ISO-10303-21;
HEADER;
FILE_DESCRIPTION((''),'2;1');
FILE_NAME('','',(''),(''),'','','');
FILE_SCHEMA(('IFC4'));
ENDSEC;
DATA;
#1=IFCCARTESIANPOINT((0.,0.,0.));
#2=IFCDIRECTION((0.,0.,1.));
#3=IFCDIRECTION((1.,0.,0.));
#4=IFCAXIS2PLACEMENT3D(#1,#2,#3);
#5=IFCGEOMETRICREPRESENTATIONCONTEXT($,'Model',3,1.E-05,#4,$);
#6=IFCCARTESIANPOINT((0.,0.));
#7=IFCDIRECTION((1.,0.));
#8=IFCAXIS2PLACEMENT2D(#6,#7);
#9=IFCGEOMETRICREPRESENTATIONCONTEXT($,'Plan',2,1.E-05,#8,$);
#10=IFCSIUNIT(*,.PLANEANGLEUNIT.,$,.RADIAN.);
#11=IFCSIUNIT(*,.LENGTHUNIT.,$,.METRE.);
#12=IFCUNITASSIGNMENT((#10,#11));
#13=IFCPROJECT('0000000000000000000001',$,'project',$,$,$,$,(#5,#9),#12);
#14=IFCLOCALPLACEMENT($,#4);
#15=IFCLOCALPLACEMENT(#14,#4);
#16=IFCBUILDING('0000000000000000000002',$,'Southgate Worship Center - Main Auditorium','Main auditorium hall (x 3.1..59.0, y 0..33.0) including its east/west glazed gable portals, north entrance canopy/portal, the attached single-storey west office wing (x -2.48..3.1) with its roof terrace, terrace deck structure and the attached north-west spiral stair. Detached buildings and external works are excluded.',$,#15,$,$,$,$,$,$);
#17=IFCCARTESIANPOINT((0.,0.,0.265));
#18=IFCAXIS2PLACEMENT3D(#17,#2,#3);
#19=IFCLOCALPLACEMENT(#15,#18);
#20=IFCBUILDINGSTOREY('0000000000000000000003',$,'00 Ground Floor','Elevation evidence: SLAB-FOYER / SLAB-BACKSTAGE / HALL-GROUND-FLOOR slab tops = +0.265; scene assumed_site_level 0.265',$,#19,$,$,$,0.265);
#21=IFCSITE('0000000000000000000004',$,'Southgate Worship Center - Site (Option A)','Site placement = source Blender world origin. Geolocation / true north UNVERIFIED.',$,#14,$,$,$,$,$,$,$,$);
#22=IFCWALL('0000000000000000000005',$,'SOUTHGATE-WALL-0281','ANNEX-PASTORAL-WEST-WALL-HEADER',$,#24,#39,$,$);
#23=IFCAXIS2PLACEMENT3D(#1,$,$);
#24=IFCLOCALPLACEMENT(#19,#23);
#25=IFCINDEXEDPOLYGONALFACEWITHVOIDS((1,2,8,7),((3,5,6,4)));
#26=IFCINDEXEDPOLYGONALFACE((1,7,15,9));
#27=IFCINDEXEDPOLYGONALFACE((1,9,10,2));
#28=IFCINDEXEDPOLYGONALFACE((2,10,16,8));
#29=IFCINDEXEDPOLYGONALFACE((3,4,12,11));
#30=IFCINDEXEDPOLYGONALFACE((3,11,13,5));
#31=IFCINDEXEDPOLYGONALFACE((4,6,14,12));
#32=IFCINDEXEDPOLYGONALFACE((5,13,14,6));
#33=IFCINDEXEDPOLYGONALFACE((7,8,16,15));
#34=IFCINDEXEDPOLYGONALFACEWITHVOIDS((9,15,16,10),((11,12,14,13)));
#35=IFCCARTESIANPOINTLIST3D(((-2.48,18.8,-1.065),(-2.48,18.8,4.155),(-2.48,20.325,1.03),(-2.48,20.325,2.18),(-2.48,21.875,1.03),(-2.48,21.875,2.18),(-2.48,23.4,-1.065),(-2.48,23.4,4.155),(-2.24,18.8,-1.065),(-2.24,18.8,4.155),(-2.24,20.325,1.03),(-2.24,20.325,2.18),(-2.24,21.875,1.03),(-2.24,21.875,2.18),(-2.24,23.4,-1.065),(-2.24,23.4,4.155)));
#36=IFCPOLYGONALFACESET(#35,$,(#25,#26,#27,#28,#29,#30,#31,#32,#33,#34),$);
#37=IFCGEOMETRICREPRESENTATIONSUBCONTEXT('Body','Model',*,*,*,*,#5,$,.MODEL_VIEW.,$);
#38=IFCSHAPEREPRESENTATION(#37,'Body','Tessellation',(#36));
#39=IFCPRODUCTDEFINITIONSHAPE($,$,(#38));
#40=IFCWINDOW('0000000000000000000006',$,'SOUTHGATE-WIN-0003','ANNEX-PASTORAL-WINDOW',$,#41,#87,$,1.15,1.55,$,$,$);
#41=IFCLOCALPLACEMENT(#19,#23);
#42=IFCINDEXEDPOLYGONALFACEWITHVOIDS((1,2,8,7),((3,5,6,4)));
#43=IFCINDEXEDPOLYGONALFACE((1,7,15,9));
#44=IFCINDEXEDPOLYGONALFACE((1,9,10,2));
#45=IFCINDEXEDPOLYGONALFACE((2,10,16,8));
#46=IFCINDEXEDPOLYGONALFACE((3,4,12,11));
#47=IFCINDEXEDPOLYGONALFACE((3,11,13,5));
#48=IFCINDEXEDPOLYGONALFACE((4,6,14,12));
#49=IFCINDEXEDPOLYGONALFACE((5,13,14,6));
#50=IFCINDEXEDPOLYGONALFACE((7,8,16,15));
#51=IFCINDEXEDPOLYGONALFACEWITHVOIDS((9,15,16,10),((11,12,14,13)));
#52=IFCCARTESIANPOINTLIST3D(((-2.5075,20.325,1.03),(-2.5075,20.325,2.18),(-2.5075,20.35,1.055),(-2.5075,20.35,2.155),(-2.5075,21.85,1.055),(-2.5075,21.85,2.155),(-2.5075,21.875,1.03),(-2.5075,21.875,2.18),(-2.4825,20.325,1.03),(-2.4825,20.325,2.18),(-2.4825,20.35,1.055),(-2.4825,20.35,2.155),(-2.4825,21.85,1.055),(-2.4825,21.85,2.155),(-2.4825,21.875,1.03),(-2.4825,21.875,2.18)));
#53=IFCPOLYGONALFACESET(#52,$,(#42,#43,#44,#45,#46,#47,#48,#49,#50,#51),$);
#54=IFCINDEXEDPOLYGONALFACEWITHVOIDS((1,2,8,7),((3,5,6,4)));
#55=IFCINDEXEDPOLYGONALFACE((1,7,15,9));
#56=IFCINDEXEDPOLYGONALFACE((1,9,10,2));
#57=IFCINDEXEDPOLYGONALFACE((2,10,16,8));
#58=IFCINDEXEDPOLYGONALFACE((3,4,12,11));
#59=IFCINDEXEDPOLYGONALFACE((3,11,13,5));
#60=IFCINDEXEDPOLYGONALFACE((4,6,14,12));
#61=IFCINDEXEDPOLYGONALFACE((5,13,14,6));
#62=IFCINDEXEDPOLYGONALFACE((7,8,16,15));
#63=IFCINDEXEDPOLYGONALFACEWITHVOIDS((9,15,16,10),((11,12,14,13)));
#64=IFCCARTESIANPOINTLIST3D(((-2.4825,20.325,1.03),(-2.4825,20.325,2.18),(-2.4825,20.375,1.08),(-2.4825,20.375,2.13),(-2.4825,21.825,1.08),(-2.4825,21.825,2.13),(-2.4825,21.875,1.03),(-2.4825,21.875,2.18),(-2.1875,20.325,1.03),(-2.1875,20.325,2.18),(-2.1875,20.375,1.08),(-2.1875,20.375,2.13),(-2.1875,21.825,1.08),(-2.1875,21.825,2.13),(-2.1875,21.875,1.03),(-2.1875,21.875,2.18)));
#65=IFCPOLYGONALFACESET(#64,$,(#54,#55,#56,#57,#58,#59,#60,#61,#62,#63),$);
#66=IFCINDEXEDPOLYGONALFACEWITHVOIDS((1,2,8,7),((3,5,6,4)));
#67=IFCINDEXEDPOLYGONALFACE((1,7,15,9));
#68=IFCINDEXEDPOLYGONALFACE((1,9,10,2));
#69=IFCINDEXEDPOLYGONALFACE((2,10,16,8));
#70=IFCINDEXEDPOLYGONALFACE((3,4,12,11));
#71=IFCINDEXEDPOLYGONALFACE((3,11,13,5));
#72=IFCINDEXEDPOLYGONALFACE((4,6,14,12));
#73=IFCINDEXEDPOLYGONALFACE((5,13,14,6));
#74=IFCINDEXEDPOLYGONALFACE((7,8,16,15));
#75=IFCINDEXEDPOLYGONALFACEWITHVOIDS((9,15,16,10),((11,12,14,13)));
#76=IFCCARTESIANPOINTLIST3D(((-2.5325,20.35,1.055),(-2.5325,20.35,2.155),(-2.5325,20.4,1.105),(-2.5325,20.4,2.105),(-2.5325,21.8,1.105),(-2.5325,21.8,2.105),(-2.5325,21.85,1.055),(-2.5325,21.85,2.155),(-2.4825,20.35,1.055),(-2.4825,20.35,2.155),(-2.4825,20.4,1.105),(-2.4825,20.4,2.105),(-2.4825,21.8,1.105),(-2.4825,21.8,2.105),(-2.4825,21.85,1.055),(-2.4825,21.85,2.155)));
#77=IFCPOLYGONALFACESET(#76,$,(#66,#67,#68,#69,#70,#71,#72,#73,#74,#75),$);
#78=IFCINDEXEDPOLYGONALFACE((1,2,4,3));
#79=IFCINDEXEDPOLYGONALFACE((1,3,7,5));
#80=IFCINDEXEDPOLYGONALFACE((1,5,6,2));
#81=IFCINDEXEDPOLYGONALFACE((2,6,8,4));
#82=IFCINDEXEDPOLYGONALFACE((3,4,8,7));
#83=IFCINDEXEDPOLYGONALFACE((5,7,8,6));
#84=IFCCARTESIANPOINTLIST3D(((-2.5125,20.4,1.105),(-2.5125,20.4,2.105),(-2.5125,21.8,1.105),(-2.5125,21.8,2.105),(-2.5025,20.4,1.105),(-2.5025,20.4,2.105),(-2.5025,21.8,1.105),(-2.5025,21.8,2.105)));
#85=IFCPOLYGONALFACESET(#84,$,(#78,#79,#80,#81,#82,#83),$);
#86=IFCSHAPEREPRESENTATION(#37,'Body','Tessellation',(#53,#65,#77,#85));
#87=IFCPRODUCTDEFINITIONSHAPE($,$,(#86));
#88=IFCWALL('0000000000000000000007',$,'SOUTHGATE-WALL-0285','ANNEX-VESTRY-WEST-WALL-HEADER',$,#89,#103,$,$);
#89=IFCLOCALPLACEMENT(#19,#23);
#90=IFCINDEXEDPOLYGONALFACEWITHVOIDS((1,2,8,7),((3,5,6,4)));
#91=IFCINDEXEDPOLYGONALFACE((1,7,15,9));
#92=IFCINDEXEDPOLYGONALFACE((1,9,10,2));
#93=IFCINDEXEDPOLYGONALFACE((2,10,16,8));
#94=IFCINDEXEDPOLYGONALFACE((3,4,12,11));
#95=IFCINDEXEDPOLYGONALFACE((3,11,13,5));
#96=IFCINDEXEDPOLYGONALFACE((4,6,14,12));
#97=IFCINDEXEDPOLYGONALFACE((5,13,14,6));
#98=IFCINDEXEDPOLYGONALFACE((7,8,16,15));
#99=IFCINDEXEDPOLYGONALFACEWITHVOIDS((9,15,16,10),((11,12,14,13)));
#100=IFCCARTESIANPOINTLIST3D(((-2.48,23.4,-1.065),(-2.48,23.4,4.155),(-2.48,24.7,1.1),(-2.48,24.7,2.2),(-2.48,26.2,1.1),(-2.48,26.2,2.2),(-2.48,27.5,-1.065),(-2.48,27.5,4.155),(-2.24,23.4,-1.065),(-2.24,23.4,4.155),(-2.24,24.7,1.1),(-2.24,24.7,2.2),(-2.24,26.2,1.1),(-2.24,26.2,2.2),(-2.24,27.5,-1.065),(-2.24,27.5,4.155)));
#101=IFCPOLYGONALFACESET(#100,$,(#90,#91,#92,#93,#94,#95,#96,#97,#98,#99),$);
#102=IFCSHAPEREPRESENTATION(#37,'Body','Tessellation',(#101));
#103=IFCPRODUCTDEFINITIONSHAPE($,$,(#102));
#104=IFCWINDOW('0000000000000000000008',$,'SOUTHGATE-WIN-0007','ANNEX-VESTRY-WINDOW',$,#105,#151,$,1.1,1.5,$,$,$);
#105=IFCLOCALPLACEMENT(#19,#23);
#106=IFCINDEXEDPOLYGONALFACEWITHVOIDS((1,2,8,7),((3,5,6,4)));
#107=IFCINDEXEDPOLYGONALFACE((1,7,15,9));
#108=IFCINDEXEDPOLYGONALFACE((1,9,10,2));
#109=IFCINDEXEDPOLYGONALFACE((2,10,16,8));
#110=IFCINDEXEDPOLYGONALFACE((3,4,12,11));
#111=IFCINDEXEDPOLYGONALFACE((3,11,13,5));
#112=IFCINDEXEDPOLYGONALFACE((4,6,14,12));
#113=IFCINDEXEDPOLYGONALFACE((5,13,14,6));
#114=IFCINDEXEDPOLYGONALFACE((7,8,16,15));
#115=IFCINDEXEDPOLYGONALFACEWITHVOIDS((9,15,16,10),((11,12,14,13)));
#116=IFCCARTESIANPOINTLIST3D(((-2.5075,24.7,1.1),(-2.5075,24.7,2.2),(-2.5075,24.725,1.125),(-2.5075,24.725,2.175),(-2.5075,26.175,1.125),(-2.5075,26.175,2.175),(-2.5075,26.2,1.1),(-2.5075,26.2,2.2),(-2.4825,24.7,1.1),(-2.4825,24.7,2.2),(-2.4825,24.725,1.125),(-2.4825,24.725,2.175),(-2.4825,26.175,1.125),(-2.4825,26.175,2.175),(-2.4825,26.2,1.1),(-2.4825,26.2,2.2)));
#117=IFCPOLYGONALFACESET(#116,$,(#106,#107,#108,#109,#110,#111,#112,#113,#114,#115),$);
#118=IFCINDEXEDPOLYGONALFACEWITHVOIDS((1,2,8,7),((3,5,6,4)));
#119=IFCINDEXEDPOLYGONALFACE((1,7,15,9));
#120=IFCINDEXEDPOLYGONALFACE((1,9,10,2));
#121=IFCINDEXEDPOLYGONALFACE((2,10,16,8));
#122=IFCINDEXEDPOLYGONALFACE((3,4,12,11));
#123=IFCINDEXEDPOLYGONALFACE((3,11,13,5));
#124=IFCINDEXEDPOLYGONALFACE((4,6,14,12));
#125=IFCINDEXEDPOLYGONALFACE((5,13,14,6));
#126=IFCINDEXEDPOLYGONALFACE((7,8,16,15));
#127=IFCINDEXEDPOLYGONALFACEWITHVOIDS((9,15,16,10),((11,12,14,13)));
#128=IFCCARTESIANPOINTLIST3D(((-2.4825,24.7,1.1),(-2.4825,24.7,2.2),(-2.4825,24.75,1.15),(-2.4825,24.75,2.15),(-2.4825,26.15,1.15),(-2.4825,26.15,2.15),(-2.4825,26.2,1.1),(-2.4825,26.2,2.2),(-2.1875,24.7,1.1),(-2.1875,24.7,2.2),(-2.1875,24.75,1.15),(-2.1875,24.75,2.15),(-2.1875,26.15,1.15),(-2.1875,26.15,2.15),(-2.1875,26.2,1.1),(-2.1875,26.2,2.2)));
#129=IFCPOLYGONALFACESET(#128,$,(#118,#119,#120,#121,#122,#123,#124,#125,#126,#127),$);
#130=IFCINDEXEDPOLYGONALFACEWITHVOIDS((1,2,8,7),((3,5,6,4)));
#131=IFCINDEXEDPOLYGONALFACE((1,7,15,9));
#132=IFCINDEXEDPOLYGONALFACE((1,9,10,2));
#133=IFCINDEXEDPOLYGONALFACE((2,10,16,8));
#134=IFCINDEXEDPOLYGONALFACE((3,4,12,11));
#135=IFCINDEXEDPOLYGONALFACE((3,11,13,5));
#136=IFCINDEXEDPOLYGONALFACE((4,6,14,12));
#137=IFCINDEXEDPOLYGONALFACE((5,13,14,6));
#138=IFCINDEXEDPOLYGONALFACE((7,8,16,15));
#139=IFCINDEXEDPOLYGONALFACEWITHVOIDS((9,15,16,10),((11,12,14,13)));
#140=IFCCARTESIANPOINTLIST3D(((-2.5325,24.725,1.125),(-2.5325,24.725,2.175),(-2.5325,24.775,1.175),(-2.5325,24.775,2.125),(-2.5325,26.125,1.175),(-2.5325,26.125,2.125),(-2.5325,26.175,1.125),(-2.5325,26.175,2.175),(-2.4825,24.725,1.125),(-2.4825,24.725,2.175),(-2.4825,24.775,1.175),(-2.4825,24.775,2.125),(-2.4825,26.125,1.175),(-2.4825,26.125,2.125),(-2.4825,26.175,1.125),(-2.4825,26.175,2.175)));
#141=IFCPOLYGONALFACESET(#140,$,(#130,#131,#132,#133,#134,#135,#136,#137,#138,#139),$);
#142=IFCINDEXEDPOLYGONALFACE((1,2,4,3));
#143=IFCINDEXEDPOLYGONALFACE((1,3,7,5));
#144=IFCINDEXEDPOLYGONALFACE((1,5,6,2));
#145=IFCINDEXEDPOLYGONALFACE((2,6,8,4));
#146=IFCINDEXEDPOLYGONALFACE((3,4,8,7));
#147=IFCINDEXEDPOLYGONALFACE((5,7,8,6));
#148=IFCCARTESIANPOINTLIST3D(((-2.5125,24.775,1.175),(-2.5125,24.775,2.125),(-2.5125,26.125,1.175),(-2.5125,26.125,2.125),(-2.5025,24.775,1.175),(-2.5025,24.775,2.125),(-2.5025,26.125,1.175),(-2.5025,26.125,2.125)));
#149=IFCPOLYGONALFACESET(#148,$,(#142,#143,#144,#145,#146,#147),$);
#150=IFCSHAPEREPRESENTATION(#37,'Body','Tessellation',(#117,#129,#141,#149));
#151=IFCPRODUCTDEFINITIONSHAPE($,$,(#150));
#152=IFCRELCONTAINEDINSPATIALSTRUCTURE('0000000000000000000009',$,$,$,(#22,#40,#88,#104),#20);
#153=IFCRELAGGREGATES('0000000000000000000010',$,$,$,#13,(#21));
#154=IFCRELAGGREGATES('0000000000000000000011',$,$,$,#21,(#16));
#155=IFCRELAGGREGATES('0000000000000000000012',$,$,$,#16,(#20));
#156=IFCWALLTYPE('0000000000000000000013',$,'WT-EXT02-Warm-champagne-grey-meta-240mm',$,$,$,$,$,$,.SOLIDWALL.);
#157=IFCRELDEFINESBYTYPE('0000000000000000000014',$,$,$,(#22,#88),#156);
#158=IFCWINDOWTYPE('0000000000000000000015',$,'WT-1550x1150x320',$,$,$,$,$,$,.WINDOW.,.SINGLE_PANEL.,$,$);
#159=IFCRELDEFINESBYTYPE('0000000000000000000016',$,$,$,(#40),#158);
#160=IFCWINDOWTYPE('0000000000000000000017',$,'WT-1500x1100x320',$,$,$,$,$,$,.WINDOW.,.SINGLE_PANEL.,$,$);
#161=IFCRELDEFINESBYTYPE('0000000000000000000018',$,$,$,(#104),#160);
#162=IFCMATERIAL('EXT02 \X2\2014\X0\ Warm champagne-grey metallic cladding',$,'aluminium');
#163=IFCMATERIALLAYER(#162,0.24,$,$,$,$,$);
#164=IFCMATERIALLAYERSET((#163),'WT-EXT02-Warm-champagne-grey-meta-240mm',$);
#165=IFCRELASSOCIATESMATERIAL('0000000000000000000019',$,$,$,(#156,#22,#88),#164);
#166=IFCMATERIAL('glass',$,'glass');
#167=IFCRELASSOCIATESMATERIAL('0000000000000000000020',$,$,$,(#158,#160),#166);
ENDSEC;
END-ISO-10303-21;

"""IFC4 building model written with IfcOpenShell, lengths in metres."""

from ifc_helpers import new_model, si_unit, frame, frame_2d, origin_with_axes, origin_2d_with_axis, place, context, subcontext, project, spatial, line, indexed_curve, rectangle, outline, extrude, source, transform, mapped, material, layer, layer_set, layer_usage, type_object, type_shapes, element, fill, save


model = new_model("IFC4")

# Units and contexts
model_context = context("Model", 3, precision=1e-05, world=origin_with_axes())
plan_context = context("Plan", 2, precision=1e-05, world=origin_2d_with_axis())
body_context = subcontext(model_context, "Body", "Model", "MODEL_VIEW")
ifc_project = project(units=[si_unit("PLANEANGLEUNIT", "RADIAN"), si_unit("LENGTHUNIT", "METRE")], contexts=[model_context, plan_context])

# Site, building, storey
site_placement = place(None, origin_with_axes())
site = spatial("IfcSite", under=ifc_project, at=site_placement, Name="Southgate Worship Center - Site (Option A)", Description="Site placement = source Blender world origin. Geolocation / true north UNVERIFIED.")
building_placement = place(site_placement, origin_with_axes())
building = spatial("IfcBuilding", under=site, at=building_placement, Name="Southgate Worship Center - Main Auditorium", Description="Main auditorium hall (x 3.1..59.0, y 0..33.0) including its east/west glazed gable portals, north entrance canopy/portal, the attached single-storey west office wing (x -2.48..3.1) with its roof terrace, terrace deck structure and the attached north-west spiral stair. Detached buildings and external works are excluded.")
storey_placement = place(building_placement, frame((0.0, 0.0, 0.265), z_axis=(0.0, 0.0, 1.0), x_axis=(1.0, 0.0, 0.0)))
storey = spatial("IfcBuildingStorey", under=building, at=storey_placement, Name="00 Ground Floor", Description="Elevation evidence: SLAB-FOYER / SLAB-BACKSTAGE / HALL-GROUND-FLOOR slab tops = +0.265; scene assumed_site_level 0.265", Elevation=0.265)

# Walls, openings, windows
ifc_material_1 = material(Name="EXT02 — Warm champagne-grey metallic cladding", Category="aluminium")
ifc_layer_1 = layer(ifc_material_1, 0.24)
ifc_layer_set_1 = layer_set([ifc_layer_1], Name="WT-EXT02-Warm-champagne-grey-meta-240mm")
ifc_layer_usage_1 = layer_usage(ifc_layer_set_1, "AXIS2", "POSITIVE", 0.0)
wall_type_1 = type_object("IfcWallType", Name="WT-EXT02-Warm-champagne-grey-meta-240mm", PredefinedType="SOLIDWALL", material=ifc_layer_set_1)
wall_1_placement = place(storey_placement, frame((-2.24, 18.8, -1.065), z_axis=(0.0, 0.0, 1.0), x_axis=(0.0, 1.0, 0.0)))
wall_1 = element("IfcWall", 1, at=wall_1_placement, inside=storey, type_object=wall_type_1, material=ifc_layer_usage_1, Name="SOUTHGATE-WALL-0281", Description="ANNEX-PASTORAL-WEST-WALL-HEADER", context=body_context, shape_type="SweptSolid", body=[
    extrude(outline(indexed_curve([(0.0, 0.0), (0.0, 0.24), (4.6, 0.24), (4.6, 0.0), (0.0, 0.0)], self_intersect=False)), origin_with_axes(), (0.0, 0.0, 1.0), 5.22),
])
opening_1_placement = place(wall_1_placement, origin_with_axes())
opening_1 = element("IfcOpeningElement", 2, at=opening_1_placement, cuts=wall_1, PredefinedType="OPENING", context=body_context, shape_type="SweptSolid", body=[
    extrude(rectangle(XDim=1.55, YDim=0.34, at=frame_2d((2.3, 0.12))), frame((0.0, 0.0, 2.095), z_axis=(0.0, 0.0, 1.0), x_axis=(1.0, 0.0, 0.0)), (0.0, 0.0, 1.0), 1.15),
])
ifc_material_2 = material(Name="glass", Category="glass")
window_type_1 = type_object("IfcWindowType", Name="WT-1550x1150x320", PartitioningType="SINGLE_PANEL", PredefinedType="WINDOW", material=ifc_material_2)
shared_shape_1 = source(origin_with_axes(), body_context, "Body", "SweptSolid", [
    extrude(outline(indexed_curve([(0.0, 0.0), (1.55, 0.0), (1.55, 1.15), (0.0, 1.15)], segments=[line(1, 2, 3, 4, 1)]), holes=[indexed_curve([(0.025, 0.025), (1.525, 0.025), (1.525, 1.125), (0.025, 1.125)], segments=[line(1, 2, 3, 4, 1)])]), frame((0.0, 0.345, 0.0), z_axis=(0.0, -1.0, 0.0), x_axis=(1.0, 0.0, 0.0)), (0.0, 0.0, -1.0), 0.025),
    extrude(outline(indexed_curve([(0.0, 0.0), (1.55, 0.0), (1.55, 1.15), (0.0, 1.15)], segments=[line(1, 2, 3, 4, 1)]), holes=[indexed_curve([(0.05, 0.05), (1.5, 0.05), (1.5, 1.1), (0.05, 1.1)], segments=[line(1, 2, 3, 4, 1)])]), frame((0.0, 0.05, 0.0), z_axis=(0.0, -1.0, 0.0), x_axis=(1.0, 0.0, 0.0)), (0.0, 0.0, -1.0), 0.295),
    extrude(outline(indexed_curve([(0.0, 0.0), (1.5, 0.0), (1.5, 1.1), (0.0, 1.1)], segments=[line(1, 2, 3, 4, 1)]), holes=[indexed_curve([(0.05, 0.05), (1.45, 0.05), (1.45, 1.05), (0.05, 1.05)], segments=[line(1, 2, 3, 4, 1)])]), frame((0.025, 0.345, 0.025), z_axis=(0.0, -1.0, 0.0), x_axis=(1.0, 0.0, 0.0)), (0.0, 0.0, -1.0), 0.05),
    extrude(outline(indexed_curve([(0.05, 0.05), (1.45, 0.05), (1.45, 1.05), (0.05, 1.05)], segments=[line(1, 2, 3, 4, 1)])), frame((0.025, 0.365, 0.025), z_axis=(0.0, -1.0, 0.0), x_axis=(1.0, 0.0, 0.0)), (0.0, 0.0, -1.0), 0.01),
])
type_shapes(window_type_1, [shared_shape_1])
window_1_placement = place(storey_placement, frame((-2.1375, 20.325, 1.03), z_axis=(0.0, 0.0, 1.0), x_axis=(0.0, 1.0, 0.0)))
window_1 = element("IfcWindow", 3, at=window_1_placement, inside=storey, type_object=window_type_1, Name="SOUTHGATE-WIN-0003", Description="ANNEX-PASTORAL-WINDOW", OverallHeight=1.15, OverallWidth=1.55, context=body_context, shape_type="MappedRepresentation", body=[
    mapped(shared_shape_1, transform((0.0, 0.0, 0.0), x_axis=(1.0, 0.0, 0.0), y_axis=(0.0, 1.0, 0.0), z_axis=(0.0, 0.0, 1.0), scale=1.0)),
])
fill(opening_1, window_1)
wall_2_placement = place(storey_placement, frame((-2.24, 23.4, -1.065), z_axis=(0.0, 0.0, 1.0), x_axis=(0.0, 1.0, 0.0)))
wall_2 = element("IfcWall", 4, at=wall_2_placement, inside=storey, type_object=wall_type_1, material=ifc_layer_usage_1, Name="SOUTHGATE-WALL-0285", Description="ANNEX-VESTRY-WEST-WALL-HEADER", context=body_context, shape_type="SweptSolid", body=[
    extrude(outline(indexed_curve([(0.0, 0.0), (0.0, 0.24), (4.1, 0.24), (4.1, 0.0), (0.0, 0.0)], self_intersect=False)), origin_with_axes(), (0.0, 0.0, 1.0), 5.22),
])
opening_2_placement = place(wall_2_placement, origin_with_axes())
opening_2 = element("IfcOpeningElement", 5, at=opening_2_placement, cuts=wall_2, PredefinedType="OPENING", context=body_context, shape_type="SweptSolid", body=[
    extrude(rectangle(XDim=1.5, YDim=0.34, at=frame_2d((2.05, 0.12))), frame((0.0, 0.0, 2.165), z_axis=(0.0, 0.0, 1.0), x_axis=(1.0, 0.0, 0.0)), (0.0, 0.0, 1.0), 1.1),
])
window_type_2 = type_object("IfcWindowType", Name="WT-1500x1100x320", PartitioningType="SINGLE_PANEL", PredefinedType="WINDOW", material=ifc_material_2)
shared_shape_2 = source(origin_with_axes(), body_context, "Body", "SweptSolid", [
    extrude(outline(indexed_curve([(0.0, 0.0), (1.5, 0.0), (1.5, 1.1), (0.0, 1.1)], segments=[line(1, 2, 3, 4, 1)]), holes=[indexed_curve([(0.025, 0.025), (1.475, 0.025), (1.475, 1.075), (0.025, 1.075)], segments=[line(1, 2, 3, 4, 1)])]), frame((0.0, 0.345, 0.0), z_axis=(0.0, -1.0, 0.0), x_axis=(1.0, 0.0, 0.0)), (0.0, 0.0, -1.0), 0.025),
    extrude(outline(indexed_curve([(0.0, 0.0), (1.5, 0.0), (1.5, 1.1), (0.0, 1.1)], segments=[line(1, 2, 3, 4, 1)]), holes=[indexed_curve([(0.05, 0.05), (1.45, 0.05), (1.45, 1.05), (0.05, 1.05)], segments=[line(1, 2, 3, 4, 1)])]), frame((0.0, 0.05, 0.0), z_axis=(0.0, -1.0, 0.0), x_axis=(1.0, 0.0, 0.0)), (0.0, 0.0, -1.0), 0.295),
    extrude(outline(indexed_curve([(0.0, 0.0), (1.45, 0.0), (1.45, 1.05), (0.0, 1.05)], segments=[line(1, 2, 3, 4, 1)]), holes=[indexed_curve([(0.05, 0.05), (1.4, 0.05), (1.4, 1.0), (0.05, 1.0)], segments=[line(1, 2, 3, 4, 1)])]), frame((0.025, 0.345, 0.025), z_axis=(0.0, -1.0, 0.0), x_axis=(1.0, 0.0, 0.0)), (0.0, 0.0, -1.0), 0.05),
    extrude(outline(indexed_curve([(0.05, 0.05), (1.4, 0.05), (1.4, 1.0), (0.05, 1.0)], segments=[line(1, 2, 3, 4, 1)])), frame((0.025, 0.365, 0.025), z_axis=(0.0, -1.0, 0.0), x_axis=(1.0, 0.0, 0.0)), (0.0, 0.0, -1.0), 0.01),
])
type_shapes(window_type_2, [shared_shape_2])
window_2_placement = place(storey_placement, frame((-2.1375, 24.7, 1.1), z_axis=(0.0, 0.0, 1.0), x_axis=(0.0, 1.0, 0.0)))
window_2 = element("IfcWindow", 6, at=window_2_placement, inside=storey, type_object=window_type_2, Name="SOUTHGATE-WIN-0007", Description="ANNEX-VESTRY-WINDOW", OverallHeight=1.1, OverallWidth=1.5, context=body_context, shape_type="MappedRepresentation", body=[
    mapped(shared_shape_2, transform((0.0, 0.0, 0.0), x_axis=(1.0, 0.0, 0.0), y_axis=(0.0, 1.0, 0.0), z_axis=(0.0, 0.0, 1.0), scale=1.0)),
])
fill(opening_2, window_2)

save(model, "model.ifc")
